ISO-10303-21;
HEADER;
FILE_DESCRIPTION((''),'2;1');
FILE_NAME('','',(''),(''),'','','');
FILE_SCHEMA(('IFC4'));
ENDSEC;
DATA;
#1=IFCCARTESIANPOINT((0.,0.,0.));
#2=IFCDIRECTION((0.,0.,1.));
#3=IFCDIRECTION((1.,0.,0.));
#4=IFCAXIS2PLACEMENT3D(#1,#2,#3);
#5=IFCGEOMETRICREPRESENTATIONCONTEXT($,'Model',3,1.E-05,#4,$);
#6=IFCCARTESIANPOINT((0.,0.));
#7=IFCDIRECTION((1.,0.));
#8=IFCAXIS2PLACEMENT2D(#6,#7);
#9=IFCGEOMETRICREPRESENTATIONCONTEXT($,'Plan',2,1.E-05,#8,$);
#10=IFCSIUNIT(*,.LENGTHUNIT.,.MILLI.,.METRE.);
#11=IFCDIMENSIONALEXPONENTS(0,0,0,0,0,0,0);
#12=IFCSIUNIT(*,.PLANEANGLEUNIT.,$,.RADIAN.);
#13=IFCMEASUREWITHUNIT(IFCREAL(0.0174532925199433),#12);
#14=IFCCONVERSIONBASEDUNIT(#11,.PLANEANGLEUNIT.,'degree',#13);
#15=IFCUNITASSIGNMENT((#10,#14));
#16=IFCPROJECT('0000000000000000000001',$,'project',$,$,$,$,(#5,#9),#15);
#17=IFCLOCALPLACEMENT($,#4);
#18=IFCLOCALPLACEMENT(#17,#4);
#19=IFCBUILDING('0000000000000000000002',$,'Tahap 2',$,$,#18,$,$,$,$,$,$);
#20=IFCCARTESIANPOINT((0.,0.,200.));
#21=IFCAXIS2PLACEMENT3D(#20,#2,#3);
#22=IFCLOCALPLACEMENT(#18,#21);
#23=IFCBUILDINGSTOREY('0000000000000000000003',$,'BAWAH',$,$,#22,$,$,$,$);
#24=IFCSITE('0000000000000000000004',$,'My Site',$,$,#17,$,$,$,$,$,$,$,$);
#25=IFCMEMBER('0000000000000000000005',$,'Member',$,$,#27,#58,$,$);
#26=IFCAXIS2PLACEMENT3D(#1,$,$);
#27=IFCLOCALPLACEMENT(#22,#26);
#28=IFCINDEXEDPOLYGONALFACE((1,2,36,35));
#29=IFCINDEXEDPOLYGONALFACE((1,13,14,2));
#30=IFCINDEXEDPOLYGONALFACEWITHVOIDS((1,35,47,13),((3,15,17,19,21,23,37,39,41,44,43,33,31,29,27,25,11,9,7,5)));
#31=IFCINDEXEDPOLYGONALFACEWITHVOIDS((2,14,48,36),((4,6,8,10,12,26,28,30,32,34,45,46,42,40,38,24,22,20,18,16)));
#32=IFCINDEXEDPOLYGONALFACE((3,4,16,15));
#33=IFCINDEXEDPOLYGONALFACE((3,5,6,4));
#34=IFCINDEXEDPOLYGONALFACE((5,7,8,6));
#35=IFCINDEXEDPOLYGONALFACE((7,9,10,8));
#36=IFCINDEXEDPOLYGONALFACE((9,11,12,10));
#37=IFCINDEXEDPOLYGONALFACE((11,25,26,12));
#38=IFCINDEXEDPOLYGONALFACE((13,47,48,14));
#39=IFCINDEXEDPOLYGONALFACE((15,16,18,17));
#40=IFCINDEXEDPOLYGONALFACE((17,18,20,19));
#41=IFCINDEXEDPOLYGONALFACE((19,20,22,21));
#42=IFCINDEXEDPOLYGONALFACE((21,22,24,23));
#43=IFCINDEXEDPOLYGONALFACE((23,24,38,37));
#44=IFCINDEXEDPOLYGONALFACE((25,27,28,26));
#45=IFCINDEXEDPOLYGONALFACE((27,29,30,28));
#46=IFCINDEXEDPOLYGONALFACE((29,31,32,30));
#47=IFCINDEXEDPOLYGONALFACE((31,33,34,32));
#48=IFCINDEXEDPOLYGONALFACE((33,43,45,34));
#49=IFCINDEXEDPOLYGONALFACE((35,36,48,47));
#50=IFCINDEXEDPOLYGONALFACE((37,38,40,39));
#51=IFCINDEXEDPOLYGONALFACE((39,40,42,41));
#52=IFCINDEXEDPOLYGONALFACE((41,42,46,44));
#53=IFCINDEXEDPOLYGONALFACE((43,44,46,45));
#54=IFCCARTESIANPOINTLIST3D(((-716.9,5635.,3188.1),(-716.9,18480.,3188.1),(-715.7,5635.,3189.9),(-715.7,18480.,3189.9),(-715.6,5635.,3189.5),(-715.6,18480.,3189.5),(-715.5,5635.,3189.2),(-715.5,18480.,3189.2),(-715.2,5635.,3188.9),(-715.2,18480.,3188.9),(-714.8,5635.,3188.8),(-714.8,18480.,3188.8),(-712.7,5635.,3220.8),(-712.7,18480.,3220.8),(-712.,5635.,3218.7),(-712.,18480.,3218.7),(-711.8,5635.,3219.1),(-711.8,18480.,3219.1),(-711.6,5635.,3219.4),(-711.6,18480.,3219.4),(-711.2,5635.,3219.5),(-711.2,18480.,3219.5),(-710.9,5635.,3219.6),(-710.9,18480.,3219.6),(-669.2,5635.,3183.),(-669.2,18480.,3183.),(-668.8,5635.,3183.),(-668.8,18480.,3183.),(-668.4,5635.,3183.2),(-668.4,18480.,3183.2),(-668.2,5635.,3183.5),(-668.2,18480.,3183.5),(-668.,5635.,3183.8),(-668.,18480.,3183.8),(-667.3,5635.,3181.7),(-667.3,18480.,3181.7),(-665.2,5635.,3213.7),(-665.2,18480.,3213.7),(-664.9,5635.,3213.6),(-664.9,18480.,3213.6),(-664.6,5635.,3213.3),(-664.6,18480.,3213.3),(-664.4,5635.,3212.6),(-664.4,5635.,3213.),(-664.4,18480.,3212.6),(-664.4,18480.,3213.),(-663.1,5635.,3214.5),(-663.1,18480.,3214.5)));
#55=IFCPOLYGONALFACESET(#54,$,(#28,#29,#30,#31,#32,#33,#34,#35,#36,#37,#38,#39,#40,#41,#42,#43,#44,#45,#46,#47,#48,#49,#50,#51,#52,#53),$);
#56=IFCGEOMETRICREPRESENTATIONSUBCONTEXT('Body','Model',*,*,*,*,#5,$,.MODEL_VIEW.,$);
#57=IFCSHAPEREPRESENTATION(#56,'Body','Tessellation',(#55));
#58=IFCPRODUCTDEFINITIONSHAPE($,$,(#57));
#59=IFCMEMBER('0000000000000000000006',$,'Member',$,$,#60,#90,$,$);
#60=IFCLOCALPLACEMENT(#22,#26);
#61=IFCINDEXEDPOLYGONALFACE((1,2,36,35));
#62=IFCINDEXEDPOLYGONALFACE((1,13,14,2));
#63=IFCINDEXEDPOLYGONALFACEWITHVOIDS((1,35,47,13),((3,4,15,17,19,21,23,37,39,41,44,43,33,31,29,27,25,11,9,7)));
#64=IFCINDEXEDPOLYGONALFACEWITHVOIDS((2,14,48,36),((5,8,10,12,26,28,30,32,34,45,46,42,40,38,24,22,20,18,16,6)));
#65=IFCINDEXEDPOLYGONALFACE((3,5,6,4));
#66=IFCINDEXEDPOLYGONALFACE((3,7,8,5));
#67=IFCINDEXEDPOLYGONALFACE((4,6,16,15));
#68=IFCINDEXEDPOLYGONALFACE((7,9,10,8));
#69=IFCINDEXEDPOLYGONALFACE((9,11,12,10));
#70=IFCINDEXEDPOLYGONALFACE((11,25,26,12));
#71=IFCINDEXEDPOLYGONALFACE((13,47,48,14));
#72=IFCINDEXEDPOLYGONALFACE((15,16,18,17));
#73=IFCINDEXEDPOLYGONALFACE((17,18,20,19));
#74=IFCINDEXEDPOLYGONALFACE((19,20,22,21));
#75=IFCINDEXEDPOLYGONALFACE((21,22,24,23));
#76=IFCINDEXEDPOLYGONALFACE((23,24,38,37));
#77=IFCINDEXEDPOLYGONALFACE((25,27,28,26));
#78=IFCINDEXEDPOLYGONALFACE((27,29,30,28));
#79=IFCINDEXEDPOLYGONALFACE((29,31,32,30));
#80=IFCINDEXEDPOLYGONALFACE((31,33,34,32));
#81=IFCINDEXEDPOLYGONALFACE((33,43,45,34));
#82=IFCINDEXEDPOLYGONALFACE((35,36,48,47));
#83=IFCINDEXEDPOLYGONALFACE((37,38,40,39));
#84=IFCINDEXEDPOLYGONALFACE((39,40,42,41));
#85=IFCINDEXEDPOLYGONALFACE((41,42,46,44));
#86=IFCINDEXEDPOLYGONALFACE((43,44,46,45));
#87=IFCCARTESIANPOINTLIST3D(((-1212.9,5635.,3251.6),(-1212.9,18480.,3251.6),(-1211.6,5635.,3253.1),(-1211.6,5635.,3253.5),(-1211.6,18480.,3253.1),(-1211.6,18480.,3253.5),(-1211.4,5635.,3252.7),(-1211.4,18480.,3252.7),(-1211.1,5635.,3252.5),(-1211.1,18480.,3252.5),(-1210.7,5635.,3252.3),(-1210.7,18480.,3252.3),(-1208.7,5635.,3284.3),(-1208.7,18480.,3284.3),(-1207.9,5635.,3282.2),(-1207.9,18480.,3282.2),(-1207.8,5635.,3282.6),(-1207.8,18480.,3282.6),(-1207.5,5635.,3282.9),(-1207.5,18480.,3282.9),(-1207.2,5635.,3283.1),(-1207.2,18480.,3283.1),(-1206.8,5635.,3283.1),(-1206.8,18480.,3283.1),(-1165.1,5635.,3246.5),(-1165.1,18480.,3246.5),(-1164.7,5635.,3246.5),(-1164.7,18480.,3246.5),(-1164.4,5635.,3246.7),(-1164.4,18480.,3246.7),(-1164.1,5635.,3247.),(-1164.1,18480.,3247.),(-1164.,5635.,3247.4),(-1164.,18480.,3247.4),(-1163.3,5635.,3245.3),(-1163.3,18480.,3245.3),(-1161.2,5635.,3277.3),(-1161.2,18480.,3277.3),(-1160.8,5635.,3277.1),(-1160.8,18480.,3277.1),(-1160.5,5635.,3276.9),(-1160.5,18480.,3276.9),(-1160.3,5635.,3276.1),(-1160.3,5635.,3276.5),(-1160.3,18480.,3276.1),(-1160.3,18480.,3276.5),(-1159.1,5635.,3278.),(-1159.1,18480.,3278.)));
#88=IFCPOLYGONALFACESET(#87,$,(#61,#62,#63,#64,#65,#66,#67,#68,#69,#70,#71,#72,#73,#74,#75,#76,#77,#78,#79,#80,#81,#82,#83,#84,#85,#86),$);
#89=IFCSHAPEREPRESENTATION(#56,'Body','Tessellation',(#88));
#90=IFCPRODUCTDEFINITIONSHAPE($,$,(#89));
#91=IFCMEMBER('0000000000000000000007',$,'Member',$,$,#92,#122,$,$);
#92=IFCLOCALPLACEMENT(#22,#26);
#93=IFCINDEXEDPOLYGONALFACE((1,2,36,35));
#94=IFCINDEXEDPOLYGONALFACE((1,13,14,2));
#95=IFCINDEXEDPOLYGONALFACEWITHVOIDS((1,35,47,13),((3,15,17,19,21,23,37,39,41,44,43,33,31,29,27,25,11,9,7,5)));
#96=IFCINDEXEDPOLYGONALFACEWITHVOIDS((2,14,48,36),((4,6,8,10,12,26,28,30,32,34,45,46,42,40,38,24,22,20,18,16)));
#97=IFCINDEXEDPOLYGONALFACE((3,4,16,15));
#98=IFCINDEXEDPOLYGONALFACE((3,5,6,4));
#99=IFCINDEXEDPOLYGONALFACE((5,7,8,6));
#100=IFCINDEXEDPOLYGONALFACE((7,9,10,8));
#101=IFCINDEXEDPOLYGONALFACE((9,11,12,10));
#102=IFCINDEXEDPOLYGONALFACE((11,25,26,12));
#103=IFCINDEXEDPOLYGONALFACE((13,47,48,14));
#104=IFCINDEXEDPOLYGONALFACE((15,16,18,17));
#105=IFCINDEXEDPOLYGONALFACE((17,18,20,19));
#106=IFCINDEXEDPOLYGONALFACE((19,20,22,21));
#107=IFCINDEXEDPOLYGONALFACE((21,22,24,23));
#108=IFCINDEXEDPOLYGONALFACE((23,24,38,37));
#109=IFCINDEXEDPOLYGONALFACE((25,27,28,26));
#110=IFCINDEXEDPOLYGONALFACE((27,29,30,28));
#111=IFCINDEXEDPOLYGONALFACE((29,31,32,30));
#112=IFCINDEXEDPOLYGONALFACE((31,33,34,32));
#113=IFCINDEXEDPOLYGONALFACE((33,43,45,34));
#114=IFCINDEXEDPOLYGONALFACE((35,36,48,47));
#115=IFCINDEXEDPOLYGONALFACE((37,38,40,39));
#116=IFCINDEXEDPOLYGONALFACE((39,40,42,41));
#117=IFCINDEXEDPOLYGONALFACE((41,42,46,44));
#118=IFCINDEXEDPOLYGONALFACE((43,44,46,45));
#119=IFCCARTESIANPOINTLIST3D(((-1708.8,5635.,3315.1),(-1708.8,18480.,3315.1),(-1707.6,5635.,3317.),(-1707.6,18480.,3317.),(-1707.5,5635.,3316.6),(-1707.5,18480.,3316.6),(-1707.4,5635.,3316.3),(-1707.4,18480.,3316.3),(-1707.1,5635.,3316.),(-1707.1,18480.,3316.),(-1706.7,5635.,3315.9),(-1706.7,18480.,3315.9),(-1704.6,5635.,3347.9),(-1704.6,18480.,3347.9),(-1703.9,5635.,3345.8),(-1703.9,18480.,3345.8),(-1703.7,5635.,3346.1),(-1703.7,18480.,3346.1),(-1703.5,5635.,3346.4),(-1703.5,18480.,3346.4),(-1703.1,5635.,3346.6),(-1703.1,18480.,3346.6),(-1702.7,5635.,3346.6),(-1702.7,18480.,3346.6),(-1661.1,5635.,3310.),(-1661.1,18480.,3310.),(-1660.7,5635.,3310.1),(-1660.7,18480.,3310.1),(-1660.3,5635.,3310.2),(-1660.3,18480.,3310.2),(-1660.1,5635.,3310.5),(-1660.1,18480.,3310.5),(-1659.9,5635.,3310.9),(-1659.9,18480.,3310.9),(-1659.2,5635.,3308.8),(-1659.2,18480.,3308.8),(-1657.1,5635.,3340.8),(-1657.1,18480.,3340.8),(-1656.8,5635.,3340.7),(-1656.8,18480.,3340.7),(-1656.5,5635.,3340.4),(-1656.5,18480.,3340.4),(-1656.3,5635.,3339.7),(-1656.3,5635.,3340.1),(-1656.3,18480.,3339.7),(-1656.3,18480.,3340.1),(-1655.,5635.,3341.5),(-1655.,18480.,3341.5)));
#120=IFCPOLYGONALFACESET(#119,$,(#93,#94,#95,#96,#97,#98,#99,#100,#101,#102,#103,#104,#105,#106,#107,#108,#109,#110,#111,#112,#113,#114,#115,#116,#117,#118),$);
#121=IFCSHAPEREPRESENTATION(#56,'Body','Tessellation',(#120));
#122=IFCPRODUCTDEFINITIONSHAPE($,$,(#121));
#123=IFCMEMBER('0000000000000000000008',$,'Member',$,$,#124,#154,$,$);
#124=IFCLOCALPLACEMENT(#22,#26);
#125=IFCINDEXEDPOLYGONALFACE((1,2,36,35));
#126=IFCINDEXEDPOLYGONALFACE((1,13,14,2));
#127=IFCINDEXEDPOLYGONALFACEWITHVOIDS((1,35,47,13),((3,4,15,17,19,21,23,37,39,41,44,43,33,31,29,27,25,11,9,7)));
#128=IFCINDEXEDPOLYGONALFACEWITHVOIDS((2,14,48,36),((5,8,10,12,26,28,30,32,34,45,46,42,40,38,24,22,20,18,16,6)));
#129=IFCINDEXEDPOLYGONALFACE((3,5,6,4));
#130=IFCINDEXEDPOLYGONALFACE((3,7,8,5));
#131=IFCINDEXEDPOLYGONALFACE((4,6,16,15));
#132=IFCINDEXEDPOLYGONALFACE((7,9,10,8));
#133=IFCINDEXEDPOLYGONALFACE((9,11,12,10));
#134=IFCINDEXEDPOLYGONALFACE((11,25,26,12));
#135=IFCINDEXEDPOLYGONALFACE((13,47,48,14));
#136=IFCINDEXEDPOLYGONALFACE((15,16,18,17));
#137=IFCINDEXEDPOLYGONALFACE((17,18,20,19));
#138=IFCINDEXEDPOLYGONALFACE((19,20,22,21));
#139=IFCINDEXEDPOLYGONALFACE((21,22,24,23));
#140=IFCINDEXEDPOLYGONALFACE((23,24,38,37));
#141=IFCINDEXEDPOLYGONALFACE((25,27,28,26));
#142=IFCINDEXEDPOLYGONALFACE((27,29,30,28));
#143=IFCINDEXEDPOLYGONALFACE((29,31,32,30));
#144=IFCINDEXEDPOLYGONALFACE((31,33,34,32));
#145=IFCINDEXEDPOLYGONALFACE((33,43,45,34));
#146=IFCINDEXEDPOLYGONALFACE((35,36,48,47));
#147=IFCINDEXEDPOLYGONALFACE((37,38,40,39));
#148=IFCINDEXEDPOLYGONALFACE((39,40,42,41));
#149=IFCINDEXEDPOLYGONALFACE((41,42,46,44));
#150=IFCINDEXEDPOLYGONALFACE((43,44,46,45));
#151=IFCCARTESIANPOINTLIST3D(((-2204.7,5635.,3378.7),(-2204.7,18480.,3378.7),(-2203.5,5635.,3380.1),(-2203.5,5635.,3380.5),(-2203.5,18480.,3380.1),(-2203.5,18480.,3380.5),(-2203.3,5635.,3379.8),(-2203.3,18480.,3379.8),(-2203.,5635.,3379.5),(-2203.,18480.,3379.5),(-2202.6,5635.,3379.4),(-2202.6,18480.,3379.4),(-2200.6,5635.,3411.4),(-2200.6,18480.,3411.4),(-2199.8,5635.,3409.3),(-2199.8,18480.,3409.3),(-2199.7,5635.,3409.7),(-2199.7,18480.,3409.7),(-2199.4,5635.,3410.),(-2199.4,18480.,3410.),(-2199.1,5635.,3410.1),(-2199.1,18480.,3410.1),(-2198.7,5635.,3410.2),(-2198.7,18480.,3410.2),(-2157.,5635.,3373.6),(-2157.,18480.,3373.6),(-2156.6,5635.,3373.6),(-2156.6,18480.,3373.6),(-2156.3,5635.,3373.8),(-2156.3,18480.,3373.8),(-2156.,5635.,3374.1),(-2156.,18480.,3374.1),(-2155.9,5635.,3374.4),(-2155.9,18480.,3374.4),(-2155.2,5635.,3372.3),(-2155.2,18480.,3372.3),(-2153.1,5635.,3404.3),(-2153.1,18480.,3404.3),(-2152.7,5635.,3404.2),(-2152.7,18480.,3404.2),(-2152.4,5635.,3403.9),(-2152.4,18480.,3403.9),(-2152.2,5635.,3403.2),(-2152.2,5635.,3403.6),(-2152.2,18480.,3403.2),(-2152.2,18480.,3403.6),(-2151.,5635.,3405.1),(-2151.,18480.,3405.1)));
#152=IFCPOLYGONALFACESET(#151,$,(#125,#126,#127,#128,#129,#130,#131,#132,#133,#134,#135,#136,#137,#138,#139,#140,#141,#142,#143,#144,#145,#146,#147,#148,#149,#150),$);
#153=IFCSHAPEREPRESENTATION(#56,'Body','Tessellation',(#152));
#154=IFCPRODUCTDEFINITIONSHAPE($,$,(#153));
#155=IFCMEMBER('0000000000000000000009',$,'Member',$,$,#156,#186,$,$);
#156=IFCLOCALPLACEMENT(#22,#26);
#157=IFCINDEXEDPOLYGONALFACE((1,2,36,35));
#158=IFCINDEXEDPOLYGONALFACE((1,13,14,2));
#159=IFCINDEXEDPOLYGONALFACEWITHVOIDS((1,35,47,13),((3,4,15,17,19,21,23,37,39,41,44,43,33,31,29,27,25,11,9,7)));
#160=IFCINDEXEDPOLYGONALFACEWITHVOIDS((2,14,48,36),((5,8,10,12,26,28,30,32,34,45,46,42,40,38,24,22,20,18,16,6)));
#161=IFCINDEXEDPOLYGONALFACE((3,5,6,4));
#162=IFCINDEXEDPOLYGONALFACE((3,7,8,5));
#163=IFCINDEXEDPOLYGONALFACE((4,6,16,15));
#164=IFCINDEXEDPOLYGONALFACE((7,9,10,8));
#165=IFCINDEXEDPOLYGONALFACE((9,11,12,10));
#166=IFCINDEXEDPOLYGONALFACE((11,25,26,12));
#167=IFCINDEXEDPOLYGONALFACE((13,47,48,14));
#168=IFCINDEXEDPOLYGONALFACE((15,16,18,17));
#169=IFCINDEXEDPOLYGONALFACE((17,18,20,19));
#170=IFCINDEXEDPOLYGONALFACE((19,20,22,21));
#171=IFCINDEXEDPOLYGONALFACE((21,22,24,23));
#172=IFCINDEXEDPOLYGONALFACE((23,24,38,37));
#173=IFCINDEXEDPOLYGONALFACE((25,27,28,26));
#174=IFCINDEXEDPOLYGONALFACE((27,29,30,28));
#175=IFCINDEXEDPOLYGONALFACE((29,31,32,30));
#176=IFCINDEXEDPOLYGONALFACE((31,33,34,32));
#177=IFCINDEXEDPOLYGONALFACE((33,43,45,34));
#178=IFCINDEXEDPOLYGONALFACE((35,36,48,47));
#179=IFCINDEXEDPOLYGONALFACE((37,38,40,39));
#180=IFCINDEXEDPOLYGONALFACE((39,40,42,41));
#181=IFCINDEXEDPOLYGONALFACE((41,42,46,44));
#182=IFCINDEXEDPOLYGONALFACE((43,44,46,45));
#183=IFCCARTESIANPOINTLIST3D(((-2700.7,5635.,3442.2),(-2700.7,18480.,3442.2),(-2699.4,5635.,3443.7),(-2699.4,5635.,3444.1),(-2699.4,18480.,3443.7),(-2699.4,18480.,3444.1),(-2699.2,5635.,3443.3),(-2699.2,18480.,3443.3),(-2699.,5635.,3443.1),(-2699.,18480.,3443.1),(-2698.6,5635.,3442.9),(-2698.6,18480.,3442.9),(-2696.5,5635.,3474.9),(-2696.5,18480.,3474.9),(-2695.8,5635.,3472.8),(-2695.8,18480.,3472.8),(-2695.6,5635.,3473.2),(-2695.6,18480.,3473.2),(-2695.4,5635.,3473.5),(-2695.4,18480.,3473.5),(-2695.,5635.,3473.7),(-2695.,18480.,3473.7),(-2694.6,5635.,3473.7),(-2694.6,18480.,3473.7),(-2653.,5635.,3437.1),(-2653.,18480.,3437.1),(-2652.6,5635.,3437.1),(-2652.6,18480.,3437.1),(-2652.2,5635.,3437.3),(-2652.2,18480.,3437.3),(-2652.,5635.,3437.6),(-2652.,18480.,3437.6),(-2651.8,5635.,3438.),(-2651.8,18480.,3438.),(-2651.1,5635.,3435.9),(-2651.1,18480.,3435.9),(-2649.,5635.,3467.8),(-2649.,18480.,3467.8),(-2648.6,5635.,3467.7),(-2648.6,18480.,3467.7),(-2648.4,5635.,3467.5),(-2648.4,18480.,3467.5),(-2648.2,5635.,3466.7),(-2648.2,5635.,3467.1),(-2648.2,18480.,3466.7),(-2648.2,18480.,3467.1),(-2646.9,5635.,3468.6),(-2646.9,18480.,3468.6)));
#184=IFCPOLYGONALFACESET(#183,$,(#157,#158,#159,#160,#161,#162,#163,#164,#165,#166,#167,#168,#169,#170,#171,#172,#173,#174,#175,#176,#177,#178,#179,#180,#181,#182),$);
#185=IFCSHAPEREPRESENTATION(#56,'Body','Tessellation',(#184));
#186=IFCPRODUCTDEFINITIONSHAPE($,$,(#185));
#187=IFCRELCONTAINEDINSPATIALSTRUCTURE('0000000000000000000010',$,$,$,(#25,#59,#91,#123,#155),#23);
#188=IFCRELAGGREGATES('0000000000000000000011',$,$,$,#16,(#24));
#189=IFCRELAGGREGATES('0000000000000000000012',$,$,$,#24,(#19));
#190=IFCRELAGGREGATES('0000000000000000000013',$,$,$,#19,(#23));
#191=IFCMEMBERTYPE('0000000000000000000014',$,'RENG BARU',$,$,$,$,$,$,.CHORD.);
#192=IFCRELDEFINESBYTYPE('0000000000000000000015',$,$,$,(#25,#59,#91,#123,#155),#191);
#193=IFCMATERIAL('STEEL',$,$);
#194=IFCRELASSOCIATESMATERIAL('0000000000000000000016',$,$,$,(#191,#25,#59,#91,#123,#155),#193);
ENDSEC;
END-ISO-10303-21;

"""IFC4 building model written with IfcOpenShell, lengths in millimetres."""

from ifc_helpers import new_model, entity, si_unit, converted_unit, frame, origin_with_axes, origin_2d_with_axis, place, context, subcontext, project, spatial, hollow_rectangle, extrude, material, material_profile, profile_set, profile_usage, type_object, element, save


model = new_model("IFC4")

# Units and contexts
model_context = context("Model", 3, precision=1e-05, world=origin_with_axes())
plan_context = context("Plan", 2, precision=1e-05, world=origin_2d_with_axis())
body_context = subcontext(model_context, "Body", "Model", "MODEL_VIEW")
ifc_project = project(units=[si_unit("LENGTHUNIT", "METRE", prefix="MILLI"), converted_unit("PLANEANGLEUNIT", "degree", entity("IfcReal", 0.0174532925199433), si_unit("PLANEANGLEUNIT", "RADIAN"), dimensions=[0, 0, 0, 0, 0, 0, 0])], contexts=[model_context, plan_context])

# Site, building, storey
site_placement = place(None, origin_with_axes())
site = spatial("IfcSite", under=ifc_project, at=site_placement, Name="My Site")
building_placement = place(site_placement, origin_with_axes())
building = spatial("IfcBuilding", under=site, at=building_placement, Name="Tahap 2")
storey_placement = place(building_placement, frame((0.0, 0.0, 200.0), z_axis=(0.0, 0.0, 1.0), x_axis=(1.0, 0.0, 0.0)))
storey = spatial("IfcBuildingStorey", under=building, at=storey_placement, Name="BAWAH")

# Shared definitions
ifc_material_1 = material(Name="STEEL")

# Members
ifc_material_profile_1 = material_profile(ifc_material_1, hollow_rectangle(XDim=50.0, YDim=33.0, WallThickness=1.0, InnerFilletRadius=1.0, OuterFilletRadius=0.0, kind="CURVE"))
ifc_profile_set_1 = profile_set([ifc_material_profile_1])
member_type_1 = type_object("IfcMemberType", Name="RENG BARU", PredefinedType="CHORD", material=ifc_profile_set_1)
ifc_profile_usage_1 = profile_usage(ifc_profile_set_1, cardinal=3)
member_1_placement = place(storey_placement, frame((-667.3, 5635.0, 3181.7), z_axis=(0.0, 1.0, 0.0), x_axis=(-0.991894, 0.0, 0.127065)))
element("IfcMember", 1, at=member_1_placement, inside=storey, type_object=member_type_1, material=ifc_profile_usage_1, Name="Member", context=body_context, shape_type="SweptSolid", body=[
    extrude(hollow_rectangle(XDim=50.0, YDim=33.0, WallThickness=1.0, InnerFilletRadius=1.0, OuterFilletRadius=0.0, kind="CURVE"), frame((25.0, 16.5, 0.0), z_axis=(0.0, 0.0, 1.0), x_axis=(1.0, 0.0, 0.0)), (0.0, 0.0, 1.0), 12845.0),
])
ifc_profile_usage_2 = profile_usage(ifc_profile_set_1, cardinal=3)
member_2_placement = place(storey_placement, frame((-1163.3, 5635.0, 3245.3), z_axis=(0.0, 1.0, 0.0), x_axis=(-0.991894, 0.0, 0.127065)))
element("IfcMember", 2, at=member_2_placement, inside=storey, type_object=member_type_1, material=ifc_profile_usage_2, Name="Member", context=body_context, shape_type="SweptSolid", body=[
    extrude(hollow_rectangle(XDim=50.0, YDim=33.0, WallThickness=1.0, InnerFilletRadius=1.0, OuterFilletRadius=0.0, kind="CURVE"), frame((25.0, 16.5, 0.0), z_axis=(0.0, 0.0, 1.0), x_axis=(1.0, 0.0, 0.0)), (0.0, 0.0, 1.0), 12845.0),
])
ifc_profile_usage_3 = profile_usage(ifc_profile_set_1, cardinal=3)
member_3_placement = place(storey_placement, frame((-1659.2, 5635.0, 3308.8), z_axis=(0.0, 1.0, 0.0), x_axis=(-0.991894, 0.0, 0.127065)))
element("IfcMember", 3, at=member_3_placement, inside=storey, type_object=member_type_1, material=ifc_profile_usage_3, Name="Member", context=body_context, shape_type="SweptSolid", body=[
    extrude(hollow_rectangle(XDim=50.0, YDim=33.0, WallThickness=1.0, InnerFilletRadius=1.0, OuterFilletRadius=0.0, kind="CURVE"), frame((25.0, 16.5, 0.0), z_axis=(0.0, 0.0, 1.0), x_axis=(1.0, 0.0, 0.0)), (0.0, 0.0, 1.0), 12845.0),
])
ifc_profile_usage_4 = profile_usage(ifc_profile_set_1, cardinal=3)
member_4_placement = place(storey_placement, frame((-2155.2, 5635.0, 3372.3), z_axis=(0.0, 1.0, 0.0), x_axis=(-0.991894, 0.0, 0.127065)))
element("IfcMember", 4, at=member_4_placement, inside=storey, type_object=member_type_1, material=ifc_profile_usage_4, Name="Member", context=body_context, shape_type="SweptSolid", body=[
    extrude(hollow_rectangle(XDim=50.0, YDim=33.0, WallThickness=1.0, InnerFilletRadius=1.0, OuterFilletRadius=0.0, kind="CURVE"), frame((25.0, 16.5, 0.0), z_axis=(0.0, 0.0, 1.0), x_axis=(1.0, 0.0, 0.0)), (0.0, 0.0, 1.0), 12845.0),
])
ifc_profile_usage_5 = profile_usage(ifc_profile_set_1, cardinal=3)
member_5_placement = place(storey_placement, frame((-2651.1, 5635.0, 3435.9), z_axis=(0.0, 1.0, 0.0), x_axis=(-0.991894, 0.0, 0.127065)))
element("IfcMember", 5, at=member_5_placement, inside=storey, type_object=member_type_1, material=ifc_profile_usage_5, Name="Member", context=body_context, shape_type="SweptSolid", body=[
    extrude(hollow_rectangle(XDim=50.0, YDim=33.0, WallThickness=1.0, InnerFilletRadius=1.0, OuterFilletRadius=0.0, kind="CURVE"), frame((25.0, 16.5, 0.0), z_axis=(0.0, 0.0, 1.0), x_axis=(1.0, 0.0, 0.0)), (0.0, 0.0, 1.0), 12845.0),
])

save(model, "model.ifc")
